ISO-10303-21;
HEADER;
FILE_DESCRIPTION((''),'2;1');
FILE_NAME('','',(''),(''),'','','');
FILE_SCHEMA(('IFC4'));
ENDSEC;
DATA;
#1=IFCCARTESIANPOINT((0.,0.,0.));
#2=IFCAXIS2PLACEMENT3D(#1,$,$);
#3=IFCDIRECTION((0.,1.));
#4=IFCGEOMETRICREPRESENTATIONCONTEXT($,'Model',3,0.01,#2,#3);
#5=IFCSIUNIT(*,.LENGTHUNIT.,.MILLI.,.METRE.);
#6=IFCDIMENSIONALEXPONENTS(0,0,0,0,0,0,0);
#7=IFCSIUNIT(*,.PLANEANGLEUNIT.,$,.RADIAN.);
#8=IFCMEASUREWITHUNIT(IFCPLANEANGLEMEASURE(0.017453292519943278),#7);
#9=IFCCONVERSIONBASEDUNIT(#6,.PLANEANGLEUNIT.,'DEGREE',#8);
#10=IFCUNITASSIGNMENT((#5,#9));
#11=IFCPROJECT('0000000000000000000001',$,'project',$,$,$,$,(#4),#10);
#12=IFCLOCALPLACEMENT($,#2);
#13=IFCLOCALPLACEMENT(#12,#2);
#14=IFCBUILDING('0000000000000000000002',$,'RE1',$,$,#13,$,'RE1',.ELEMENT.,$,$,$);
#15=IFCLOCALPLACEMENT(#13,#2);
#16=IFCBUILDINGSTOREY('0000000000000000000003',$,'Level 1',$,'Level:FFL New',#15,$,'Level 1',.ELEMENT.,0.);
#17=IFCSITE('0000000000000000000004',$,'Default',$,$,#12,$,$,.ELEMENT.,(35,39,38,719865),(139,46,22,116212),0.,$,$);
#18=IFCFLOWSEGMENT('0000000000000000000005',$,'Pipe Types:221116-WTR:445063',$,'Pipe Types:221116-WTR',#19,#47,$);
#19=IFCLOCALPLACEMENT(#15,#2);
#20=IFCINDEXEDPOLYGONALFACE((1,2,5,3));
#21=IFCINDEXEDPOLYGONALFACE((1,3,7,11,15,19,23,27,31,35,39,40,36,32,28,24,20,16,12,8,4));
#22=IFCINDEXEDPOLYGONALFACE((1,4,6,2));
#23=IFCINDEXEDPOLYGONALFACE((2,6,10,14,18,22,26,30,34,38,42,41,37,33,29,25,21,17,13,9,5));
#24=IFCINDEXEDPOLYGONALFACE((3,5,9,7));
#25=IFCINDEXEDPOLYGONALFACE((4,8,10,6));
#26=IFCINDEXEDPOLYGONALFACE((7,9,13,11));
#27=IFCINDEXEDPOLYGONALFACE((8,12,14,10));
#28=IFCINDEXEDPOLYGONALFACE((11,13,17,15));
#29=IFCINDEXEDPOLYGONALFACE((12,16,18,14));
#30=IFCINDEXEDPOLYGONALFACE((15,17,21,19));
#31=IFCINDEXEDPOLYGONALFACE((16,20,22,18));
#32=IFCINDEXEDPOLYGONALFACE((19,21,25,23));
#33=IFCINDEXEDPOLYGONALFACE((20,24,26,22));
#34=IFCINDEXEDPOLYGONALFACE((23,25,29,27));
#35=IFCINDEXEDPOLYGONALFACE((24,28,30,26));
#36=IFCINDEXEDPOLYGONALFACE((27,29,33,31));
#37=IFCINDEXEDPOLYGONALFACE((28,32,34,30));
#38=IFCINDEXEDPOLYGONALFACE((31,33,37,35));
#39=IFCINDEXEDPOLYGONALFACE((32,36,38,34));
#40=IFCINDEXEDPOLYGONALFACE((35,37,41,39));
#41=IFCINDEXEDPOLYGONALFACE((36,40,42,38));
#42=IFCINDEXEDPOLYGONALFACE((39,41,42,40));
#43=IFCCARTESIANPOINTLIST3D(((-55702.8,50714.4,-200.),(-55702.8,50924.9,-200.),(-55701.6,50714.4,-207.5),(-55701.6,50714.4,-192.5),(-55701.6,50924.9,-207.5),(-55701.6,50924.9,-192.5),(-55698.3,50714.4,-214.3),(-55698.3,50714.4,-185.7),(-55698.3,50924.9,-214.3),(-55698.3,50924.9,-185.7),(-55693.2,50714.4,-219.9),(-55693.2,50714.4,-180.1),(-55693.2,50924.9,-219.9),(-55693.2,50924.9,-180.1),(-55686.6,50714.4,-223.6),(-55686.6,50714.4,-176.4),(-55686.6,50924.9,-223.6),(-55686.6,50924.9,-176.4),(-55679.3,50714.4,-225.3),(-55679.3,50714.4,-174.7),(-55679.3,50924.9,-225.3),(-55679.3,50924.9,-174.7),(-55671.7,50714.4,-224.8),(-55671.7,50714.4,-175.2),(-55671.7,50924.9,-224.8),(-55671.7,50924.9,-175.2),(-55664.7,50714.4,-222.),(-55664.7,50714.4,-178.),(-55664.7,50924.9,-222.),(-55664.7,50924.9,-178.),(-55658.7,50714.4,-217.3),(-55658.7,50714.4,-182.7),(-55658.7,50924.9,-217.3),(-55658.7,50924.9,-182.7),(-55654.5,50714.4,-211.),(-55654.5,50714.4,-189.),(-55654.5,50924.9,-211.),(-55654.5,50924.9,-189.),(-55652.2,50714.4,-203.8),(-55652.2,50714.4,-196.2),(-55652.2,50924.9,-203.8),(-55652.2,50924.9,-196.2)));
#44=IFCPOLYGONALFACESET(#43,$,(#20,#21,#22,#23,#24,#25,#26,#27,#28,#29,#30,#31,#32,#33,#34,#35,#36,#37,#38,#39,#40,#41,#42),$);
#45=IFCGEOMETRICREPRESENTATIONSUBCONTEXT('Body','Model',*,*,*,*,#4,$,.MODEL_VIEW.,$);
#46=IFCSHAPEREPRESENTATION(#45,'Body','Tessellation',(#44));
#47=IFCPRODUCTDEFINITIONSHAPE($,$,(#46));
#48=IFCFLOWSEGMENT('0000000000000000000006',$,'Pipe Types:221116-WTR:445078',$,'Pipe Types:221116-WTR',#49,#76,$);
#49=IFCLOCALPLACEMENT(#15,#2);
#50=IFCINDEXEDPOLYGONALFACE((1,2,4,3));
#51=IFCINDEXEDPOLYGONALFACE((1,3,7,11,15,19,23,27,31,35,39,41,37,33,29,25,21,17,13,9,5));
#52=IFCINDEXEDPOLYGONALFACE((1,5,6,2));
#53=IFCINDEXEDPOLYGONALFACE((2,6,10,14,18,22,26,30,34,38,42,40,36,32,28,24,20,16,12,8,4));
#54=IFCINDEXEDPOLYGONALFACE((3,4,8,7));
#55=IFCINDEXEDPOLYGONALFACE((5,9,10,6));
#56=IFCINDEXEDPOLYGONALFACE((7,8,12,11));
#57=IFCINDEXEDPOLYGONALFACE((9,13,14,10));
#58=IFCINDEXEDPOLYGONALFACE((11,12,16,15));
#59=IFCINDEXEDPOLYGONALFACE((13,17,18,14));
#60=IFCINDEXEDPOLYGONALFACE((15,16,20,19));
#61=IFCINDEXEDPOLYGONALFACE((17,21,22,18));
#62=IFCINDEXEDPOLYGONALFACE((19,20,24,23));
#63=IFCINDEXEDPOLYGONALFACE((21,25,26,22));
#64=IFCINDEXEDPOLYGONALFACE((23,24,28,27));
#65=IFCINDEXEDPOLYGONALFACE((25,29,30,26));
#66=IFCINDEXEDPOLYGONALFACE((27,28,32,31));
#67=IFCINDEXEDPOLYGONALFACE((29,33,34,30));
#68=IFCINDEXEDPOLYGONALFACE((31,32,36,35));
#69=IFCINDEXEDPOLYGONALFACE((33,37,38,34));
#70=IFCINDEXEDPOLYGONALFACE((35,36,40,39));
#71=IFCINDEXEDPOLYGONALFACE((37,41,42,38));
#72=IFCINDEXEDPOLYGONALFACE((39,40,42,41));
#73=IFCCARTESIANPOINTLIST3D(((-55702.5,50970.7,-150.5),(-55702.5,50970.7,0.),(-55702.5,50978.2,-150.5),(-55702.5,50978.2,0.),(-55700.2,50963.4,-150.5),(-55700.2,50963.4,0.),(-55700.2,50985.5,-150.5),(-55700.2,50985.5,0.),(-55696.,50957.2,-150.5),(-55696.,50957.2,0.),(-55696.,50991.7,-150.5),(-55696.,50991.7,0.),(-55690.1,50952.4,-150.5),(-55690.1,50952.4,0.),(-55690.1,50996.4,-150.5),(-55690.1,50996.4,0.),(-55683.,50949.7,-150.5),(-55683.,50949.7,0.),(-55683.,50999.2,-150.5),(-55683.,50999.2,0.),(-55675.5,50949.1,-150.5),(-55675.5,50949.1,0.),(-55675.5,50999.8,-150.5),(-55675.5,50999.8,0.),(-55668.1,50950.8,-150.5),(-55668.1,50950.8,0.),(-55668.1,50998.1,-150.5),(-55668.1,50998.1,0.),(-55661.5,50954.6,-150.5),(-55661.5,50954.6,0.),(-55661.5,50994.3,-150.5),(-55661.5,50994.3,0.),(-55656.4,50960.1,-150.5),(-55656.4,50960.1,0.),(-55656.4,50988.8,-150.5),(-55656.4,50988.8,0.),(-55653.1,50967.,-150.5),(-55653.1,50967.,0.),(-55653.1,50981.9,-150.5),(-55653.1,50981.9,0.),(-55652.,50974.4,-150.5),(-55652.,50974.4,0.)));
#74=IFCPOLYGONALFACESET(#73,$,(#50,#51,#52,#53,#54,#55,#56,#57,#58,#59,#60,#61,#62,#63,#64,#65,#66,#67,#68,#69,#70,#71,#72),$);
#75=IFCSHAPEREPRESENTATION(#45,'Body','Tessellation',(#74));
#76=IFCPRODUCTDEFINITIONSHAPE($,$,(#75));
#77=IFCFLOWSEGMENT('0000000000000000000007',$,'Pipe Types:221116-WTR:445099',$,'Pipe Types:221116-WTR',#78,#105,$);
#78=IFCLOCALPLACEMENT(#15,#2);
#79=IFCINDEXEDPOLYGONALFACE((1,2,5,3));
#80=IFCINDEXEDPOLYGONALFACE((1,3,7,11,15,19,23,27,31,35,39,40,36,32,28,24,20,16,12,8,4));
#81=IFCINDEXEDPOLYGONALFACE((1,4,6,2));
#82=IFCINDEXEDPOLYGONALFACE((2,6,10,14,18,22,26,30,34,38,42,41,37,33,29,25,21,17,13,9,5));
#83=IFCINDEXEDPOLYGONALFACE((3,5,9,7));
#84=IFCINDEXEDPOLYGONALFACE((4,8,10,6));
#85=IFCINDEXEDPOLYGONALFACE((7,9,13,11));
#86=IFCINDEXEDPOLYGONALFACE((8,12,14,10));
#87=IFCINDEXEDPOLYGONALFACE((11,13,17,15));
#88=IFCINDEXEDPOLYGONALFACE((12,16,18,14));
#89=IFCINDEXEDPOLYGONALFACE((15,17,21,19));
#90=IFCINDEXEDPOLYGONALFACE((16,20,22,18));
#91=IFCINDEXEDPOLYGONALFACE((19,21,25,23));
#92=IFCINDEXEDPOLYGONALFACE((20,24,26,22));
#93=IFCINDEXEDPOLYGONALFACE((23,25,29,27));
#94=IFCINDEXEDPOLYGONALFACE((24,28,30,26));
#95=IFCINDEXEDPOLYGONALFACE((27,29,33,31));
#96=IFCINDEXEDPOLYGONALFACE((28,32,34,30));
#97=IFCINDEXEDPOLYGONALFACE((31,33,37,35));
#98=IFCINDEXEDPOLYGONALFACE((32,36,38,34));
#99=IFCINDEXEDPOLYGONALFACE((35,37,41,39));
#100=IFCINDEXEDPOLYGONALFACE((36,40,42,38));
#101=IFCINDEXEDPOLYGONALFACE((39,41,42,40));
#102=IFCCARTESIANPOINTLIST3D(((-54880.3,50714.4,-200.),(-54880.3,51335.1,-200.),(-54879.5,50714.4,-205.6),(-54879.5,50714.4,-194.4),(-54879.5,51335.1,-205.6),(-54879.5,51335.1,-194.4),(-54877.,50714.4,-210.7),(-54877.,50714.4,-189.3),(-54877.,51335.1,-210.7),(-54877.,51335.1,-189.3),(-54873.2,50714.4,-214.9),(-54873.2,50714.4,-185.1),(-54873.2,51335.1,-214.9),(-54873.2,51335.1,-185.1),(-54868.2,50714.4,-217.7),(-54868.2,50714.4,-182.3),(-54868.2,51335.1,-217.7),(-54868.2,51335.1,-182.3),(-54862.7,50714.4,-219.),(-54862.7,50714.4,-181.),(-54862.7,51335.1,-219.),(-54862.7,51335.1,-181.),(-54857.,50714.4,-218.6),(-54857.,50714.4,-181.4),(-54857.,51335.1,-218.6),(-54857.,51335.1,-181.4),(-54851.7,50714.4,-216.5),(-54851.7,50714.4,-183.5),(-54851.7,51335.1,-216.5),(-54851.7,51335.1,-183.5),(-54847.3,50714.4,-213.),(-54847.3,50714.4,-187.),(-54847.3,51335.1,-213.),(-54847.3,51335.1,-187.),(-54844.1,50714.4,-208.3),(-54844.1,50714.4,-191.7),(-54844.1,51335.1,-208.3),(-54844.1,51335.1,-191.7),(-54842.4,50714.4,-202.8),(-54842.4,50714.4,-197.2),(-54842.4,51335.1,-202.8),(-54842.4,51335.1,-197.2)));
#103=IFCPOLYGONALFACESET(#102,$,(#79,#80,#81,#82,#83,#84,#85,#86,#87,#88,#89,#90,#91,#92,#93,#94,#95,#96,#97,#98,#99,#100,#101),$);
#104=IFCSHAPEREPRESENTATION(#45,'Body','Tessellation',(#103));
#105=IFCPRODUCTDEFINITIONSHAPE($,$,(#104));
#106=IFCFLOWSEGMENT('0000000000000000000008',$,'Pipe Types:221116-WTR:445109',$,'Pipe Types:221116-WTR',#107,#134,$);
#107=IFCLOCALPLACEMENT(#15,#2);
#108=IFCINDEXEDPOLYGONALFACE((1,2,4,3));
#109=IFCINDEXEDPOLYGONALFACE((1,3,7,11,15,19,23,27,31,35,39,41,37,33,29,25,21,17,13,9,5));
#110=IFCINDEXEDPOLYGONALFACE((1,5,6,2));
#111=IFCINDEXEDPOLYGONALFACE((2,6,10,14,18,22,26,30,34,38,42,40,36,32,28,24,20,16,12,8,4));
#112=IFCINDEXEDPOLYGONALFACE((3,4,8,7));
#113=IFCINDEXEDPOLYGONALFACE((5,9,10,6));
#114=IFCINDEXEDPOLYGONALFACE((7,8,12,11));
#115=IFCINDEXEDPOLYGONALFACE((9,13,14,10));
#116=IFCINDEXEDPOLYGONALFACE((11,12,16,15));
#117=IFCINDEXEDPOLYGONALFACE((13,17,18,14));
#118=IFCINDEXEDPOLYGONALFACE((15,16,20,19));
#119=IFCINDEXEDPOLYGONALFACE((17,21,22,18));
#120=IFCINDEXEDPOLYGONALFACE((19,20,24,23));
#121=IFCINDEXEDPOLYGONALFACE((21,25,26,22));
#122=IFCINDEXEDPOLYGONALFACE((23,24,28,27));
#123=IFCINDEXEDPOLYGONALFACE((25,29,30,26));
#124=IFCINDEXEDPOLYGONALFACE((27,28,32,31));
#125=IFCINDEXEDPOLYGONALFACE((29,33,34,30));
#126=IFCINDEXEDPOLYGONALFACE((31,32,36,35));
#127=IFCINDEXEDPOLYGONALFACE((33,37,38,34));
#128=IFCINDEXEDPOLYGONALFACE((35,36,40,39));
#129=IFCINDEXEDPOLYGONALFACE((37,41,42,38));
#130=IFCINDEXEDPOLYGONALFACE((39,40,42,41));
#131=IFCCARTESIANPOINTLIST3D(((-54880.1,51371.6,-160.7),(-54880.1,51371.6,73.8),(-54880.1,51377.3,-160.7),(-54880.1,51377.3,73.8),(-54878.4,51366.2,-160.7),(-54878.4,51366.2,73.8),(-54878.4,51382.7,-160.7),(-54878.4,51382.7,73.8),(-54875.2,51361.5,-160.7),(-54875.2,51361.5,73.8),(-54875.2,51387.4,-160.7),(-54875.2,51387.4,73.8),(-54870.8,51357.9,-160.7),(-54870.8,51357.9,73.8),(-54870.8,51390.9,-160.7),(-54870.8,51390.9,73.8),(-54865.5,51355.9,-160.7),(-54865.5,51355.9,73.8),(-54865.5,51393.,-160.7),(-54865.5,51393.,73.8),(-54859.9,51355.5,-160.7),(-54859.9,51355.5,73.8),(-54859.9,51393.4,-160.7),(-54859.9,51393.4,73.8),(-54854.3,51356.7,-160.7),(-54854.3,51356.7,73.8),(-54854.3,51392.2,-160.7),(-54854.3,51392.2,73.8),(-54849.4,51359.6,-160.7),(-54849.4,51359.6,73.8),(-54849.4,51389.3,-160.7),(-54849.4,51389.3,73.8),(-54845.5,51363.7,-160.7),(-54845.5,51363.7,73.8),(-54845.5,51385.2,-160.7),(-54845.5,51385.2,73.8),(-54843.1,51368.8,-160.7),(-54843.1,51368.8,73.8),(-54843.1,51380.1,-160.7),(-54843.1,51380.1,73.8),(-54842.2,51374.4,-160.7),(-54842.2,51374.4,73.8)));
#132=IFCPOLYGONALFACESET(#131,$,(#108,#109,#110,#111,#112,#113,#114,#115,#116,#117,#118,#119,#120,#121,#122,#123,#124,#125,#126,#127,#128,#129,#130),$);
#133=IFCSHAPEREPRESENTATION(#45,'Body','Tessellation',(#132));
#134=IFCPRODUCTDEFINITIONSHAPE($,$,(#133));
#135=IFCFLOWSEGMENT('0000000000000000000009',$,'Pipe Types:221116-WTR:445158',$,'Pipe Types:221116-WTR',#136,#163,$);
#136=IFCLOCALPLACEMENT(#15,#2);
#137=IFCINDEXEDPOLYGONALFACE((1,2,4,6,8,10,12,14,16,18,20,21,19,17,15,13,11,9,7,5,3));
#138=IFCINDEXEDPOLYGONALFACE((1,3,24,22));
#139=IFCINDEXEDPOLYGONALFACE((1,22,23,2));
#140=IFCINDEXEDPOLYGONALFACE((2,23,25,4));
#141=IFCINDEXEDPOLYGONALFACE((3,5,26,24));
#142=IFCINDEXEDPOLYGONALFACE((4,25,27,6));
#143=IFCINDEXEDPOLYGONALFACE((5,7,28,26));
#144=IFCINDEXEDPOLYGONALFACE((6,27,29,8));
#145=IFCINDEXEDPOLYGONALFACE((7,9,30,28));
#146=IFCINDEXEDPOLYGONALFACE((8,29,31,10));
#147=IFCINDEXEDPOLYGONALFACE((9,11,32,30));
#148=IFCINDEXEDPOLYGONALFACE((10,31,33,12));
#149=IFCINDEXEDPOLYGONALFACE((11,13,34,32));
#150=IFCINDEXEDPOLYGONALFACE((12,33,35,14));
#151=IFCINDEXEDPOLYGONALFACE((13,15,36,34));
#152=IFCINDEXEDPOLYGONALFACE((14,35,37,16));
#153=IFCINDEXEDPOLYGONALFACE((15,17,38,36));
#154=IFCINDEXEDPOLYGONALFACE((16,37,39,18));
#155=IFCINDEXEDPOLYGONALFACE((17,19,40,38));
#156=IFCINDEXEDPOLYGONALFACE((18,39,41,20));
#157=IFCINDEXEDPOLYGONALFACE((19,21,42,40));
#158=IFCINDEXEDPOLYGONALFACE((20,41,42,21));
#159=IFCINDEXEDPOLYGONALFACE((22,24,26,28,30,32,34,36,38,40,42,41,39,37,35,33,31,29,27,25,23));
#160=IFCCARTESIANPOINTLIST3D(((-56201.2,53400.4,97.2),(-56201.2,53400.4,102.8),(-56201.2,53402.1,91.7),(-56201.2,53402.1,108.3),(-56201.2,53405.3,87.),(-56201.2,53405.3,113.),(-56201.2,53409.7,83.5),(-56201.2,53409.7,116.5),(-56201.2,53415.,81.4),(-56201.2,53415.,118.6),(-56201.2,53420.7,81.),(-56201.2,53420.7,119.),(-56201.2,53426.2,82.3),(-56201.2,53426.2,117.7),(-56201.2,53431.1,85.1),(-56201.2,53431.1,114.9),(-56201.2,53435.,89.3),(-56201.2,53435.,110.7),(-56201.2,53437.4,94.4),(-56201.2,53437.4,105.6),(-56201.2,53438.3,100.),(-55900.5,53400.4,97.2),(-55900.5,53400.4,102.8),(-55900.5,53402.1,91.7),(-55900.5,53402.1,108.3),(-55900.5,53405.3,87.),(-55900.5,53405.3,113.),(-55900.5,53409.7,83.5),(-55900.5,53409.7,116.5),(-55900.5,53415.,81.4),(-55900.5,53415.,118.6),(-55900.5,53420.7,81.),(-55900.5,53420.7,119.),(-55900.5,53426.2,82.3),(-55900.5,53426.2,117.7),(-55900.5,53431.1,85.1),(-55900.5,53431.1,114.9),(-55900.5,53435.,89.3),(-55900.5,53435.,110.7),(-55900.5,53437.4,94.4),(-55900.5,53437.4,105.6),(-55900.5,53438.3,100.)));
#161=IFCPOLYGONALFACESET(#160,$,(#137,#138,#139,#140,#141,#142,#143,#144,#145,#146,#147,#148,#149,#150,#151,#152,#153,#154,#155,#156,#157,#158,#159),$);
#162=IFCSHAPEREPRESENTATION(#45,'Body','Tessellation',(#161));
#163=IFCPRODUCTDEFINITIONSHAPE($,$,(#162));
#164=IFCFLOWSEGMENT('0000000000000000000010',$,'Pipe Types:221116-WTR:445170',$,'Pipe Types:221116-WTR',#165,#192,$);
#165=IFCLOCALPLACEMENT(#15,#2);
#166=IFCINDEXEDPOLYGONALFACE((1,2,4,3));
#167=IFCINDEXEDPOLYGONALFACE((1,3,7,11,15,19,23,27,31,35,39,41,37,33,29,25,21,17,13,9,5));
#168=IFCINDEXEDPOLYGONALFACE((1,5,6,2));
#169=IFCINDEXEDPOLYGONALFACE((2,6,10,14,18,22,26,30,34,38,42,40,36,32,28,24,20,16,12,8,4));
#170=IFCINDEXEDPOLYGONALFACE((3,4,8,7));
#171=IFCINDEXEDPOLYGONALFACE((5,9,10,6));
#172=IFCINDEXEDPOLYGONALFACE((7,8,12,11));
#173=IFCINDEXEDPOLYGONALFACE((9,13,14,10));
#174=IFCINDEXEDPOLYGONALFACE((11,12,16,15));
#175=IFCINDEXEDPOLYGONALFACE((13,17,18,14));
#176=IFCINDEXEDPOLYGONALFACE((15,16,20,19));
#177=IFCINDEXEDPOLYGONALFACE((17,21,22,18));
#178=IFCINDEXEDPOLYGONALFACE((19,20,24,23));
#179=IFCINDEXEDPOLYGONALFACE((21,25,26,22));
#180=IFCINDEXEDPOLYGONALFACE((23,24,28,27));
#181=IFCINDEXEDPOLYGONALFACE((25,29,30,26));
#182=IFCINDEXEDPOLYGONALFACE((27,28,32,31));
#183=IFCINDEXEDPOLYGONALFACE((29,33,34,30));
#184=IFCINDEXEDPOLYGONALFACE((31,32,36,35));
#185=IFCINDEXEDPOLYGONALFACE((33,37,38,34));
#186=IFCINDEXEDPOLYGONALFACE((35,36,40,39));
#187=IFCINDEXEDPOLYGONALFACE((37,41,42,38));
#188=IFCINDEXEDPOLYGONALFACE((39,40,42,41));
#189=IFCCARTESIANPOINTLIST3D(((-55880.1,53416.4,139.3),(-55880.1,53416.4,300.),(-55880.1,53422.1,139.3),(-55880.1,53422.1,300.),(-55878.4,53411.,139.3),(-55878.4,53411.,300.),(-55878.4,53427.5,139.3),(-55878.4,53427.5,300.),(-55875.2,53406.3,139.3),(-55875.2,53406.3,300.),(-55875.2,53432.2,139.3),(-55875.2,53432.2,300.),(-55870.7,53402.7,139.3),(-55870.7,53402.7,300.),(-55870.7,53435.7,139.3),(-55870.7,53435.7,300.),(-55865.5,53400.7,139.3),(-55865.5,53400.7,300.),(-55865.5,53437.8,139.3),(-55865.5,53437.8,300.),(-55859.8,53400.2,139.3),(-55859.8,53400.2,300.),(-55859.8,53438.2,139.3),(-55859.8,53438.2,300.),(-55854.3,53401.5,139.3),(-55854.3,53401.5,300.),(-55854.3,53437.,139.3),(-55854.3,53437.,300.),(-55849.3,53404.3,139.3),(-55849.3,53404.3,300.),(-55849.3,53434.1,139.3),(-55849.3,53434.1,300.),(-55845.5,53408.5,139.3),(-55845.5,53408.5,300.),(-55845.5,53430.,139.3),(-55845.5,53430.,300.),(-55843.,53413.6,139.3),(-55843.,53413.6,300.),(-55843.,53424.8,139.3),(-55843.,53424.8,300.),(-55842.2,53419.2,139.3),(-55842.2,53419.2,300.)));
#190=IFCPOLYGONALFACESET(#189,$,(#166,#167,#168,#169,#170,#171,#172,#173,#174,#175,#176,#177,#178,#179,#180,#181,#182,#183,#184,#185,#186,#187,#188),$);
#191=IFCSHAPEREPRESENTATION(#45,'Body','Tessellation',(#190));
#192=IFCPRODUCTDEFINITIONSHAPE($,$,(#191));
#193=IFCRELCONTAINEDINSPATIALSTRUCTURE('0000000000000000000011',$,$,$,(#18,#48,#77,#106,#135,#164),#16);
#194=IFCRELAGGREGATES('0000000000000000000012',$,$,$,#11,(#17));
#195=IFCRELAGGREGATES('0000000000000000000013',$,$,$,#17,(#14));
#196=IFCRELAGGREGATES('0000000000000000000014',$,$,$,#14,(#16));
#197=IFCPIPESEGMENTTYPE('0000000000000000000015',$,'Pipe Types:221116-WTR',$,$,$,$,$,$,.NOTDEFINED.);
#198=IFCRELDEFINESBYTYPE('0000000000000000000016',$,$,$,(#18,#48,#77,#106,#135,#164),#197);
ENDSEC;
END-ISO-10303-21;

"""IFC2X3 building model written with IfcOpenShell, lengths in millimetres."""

from ifc_helpers import new_model, entity, si_unit, converted_unit, direction, frame, frame_2d, origin, origin_2d_with_axis, place, context, subcontext, project, spatial, circle, extrude, type_object, element, save


model = new_model("IFC2X3")

# Units and contexts
model_context = context("Model", 3, precision=0.01, world=origin(), true_north=direction((0.0, 1.0)))
body_context = subcontext(model_context, "Body", "Model", "MODEL_VIEW")
ifc_project = project(units=[si_unit("LENGTHUNIT", "METRE", prefix="MILLI"), converted_unit("PLANEANGLEUNIT", "DEGREE", entity("IfcPlaneAngleMeasure", 0.017453292519943278), si_unit("PLANEANGLEUNIT", "RADIAN"), dimensions=[0, 0, 0, 0, 0, 0, 0])], contexts=[model_context])

# Site, building, storey
site_placement = place(None, origin())
site = spatial("IfcSite", under=ifc_project, at=site_placement, Name="Default", CompositionType="ELEMENT", RefLatitude=(35, 39, 38, 719865), RefLongitude=(139, 46, 22, 116212), RefElevation=0.0)
building_placement = place(site_placement, origin())
building = spatial("IfcBuilding", under=site, at=building_placement, Name="RE1", LongName="RE1", CompositionType="ELEMENT")
storey_placement = place(building_placement, origin())
storey = spatial("IfcBuildingStorey", under=building, at=storey_placement, Name="Level 1", ObjectType="Level:FFL New", LongName="Level 1", CompositionType="ELEMENT", Elevation=0.0)

# Flow segments
pipe_segment_type_1 = type_object("IfcPipeSegmentType", Name="Pipe Types:221116-WTR", PredefinedType="NOTDEFINED")
flow_segment_1_placement = place(storey_placement, origin())
element("IfcFlowSegment", 1, at=flow_segment_1_placement, inside=storey, type_object=pipe_segment_type_1, Name="Pipe Types:221116-WTR:445063", ObjectType="Pipe Types:221116-WTR", context=body_context, shape_type="SweptSolid", body=[
    extrude(circle(Radius=25.4, at=origin_2d_with_axis()), frame((-55677.4, 50714.4, -200.0), z_axis=(0.0, 1.0, 0.0), x_axis=(-1.0, 0.0, 0.0)), (0.0, 0.0, 1.0), 210.5),
])
flow_segment_2_placement = place(storey_placement, origin())
element("IfcFlowSegment", 2, at=flow_segment_2_placement, inside=storey, type_object=pipe_segment_type_1, Name="Pipe Types:221116-WTR:445078", ObjectType="Pipe Types:221116-WTR", context=body_context, shape_type="SweptSolid", body=[
    extrude(circle(Radius=25.4, at=origin_2d_with_axis()), frame((-55677.4, 50974.4, -150.5)), (0.0, 0.0, 1.0), 150.5),
])
flow_segment_3_placement = place(storey_placement, origin())
element("IfcFlowSegment", 3, at=flow_segment_3_placement, inside=storey, type_object=pipe_segment_type_1, Name="Pipe Types:221116-WTR:445099", ObjectType="Pipe Types:221116-WTR", context=body_context, shape_type="SweptSolid", body=[
    extrude(circle(Radius=19.1, at=frame_2d((0.0, 0.0), x_axis=(1.0, 0.0))), frame((-54861.3, 50714.4, -200.0), z_axis=(0.0, 1.0, 0.0), x_axis=(-1.0, 0.0, 0.0)), (0.0, 0.0, 1.0), 620.7),
])
flow_segment_4_placement = place(storey_placement, origin())
element("IfcFlowSegment", 4, at=flow_segment_4_placement, inside=storey, type_object=pipe_segment_type_1, Name="Pipe Types:221116-WTR:445109", ObjectType="Pipe Types:221116-WTR", context=body_context, shape_type="SweptSolid", body=[
    extrude(circle(Radius=19.1, at=origin_2d_with_axis()), frame((-54861.3, 51374.4, -160.7)), (0.0, 0.0, 1.0), 234.5),
])
flow_segment_5_placement = place(storey_placement, origin())
element("IfcFlowSegment", 5, at=flow_segment_5_placement, inside=storey, type_object=pipe_segment_type_1, Name="Pipe Types:221116-WTR:445158", ObjectType="Pipe Types:221116-WTR", context=body_context, shape_type="SweptSolid", body=[
    extrude(circle(Radius=19.1, at=frame_2d((0.0, 0.0), x_axis=(1.0, 0.0))), frame((-56201.2, 53419.2, 100.0), z_axis=(1.0, 0.0, 0.0), x_axis=(0.0, 1.0, 0.0)), (0.0, 0.0, 1.0), 300.7),
])
flow_segment_6_placement = place(storey_placement, origin())
element("IfcFlowSegment", 6, at=flow_segment_6_placement, inside=storey, type_object=pipe_segment_type_1, Name="Pipe Types:221116-WTR:445170", ObjectType="Pipe Types:221116-WTR", context=body_context, shape_type="SweptSolid", body=[
    extrude(circle(Radius=19.1, at=origin_2d_with_axis()), frame((-55861.2, 53419.2, 139.3)), (0.0, 0.0, 1.0), 160.7),
])

save(model, "model.ifc")
